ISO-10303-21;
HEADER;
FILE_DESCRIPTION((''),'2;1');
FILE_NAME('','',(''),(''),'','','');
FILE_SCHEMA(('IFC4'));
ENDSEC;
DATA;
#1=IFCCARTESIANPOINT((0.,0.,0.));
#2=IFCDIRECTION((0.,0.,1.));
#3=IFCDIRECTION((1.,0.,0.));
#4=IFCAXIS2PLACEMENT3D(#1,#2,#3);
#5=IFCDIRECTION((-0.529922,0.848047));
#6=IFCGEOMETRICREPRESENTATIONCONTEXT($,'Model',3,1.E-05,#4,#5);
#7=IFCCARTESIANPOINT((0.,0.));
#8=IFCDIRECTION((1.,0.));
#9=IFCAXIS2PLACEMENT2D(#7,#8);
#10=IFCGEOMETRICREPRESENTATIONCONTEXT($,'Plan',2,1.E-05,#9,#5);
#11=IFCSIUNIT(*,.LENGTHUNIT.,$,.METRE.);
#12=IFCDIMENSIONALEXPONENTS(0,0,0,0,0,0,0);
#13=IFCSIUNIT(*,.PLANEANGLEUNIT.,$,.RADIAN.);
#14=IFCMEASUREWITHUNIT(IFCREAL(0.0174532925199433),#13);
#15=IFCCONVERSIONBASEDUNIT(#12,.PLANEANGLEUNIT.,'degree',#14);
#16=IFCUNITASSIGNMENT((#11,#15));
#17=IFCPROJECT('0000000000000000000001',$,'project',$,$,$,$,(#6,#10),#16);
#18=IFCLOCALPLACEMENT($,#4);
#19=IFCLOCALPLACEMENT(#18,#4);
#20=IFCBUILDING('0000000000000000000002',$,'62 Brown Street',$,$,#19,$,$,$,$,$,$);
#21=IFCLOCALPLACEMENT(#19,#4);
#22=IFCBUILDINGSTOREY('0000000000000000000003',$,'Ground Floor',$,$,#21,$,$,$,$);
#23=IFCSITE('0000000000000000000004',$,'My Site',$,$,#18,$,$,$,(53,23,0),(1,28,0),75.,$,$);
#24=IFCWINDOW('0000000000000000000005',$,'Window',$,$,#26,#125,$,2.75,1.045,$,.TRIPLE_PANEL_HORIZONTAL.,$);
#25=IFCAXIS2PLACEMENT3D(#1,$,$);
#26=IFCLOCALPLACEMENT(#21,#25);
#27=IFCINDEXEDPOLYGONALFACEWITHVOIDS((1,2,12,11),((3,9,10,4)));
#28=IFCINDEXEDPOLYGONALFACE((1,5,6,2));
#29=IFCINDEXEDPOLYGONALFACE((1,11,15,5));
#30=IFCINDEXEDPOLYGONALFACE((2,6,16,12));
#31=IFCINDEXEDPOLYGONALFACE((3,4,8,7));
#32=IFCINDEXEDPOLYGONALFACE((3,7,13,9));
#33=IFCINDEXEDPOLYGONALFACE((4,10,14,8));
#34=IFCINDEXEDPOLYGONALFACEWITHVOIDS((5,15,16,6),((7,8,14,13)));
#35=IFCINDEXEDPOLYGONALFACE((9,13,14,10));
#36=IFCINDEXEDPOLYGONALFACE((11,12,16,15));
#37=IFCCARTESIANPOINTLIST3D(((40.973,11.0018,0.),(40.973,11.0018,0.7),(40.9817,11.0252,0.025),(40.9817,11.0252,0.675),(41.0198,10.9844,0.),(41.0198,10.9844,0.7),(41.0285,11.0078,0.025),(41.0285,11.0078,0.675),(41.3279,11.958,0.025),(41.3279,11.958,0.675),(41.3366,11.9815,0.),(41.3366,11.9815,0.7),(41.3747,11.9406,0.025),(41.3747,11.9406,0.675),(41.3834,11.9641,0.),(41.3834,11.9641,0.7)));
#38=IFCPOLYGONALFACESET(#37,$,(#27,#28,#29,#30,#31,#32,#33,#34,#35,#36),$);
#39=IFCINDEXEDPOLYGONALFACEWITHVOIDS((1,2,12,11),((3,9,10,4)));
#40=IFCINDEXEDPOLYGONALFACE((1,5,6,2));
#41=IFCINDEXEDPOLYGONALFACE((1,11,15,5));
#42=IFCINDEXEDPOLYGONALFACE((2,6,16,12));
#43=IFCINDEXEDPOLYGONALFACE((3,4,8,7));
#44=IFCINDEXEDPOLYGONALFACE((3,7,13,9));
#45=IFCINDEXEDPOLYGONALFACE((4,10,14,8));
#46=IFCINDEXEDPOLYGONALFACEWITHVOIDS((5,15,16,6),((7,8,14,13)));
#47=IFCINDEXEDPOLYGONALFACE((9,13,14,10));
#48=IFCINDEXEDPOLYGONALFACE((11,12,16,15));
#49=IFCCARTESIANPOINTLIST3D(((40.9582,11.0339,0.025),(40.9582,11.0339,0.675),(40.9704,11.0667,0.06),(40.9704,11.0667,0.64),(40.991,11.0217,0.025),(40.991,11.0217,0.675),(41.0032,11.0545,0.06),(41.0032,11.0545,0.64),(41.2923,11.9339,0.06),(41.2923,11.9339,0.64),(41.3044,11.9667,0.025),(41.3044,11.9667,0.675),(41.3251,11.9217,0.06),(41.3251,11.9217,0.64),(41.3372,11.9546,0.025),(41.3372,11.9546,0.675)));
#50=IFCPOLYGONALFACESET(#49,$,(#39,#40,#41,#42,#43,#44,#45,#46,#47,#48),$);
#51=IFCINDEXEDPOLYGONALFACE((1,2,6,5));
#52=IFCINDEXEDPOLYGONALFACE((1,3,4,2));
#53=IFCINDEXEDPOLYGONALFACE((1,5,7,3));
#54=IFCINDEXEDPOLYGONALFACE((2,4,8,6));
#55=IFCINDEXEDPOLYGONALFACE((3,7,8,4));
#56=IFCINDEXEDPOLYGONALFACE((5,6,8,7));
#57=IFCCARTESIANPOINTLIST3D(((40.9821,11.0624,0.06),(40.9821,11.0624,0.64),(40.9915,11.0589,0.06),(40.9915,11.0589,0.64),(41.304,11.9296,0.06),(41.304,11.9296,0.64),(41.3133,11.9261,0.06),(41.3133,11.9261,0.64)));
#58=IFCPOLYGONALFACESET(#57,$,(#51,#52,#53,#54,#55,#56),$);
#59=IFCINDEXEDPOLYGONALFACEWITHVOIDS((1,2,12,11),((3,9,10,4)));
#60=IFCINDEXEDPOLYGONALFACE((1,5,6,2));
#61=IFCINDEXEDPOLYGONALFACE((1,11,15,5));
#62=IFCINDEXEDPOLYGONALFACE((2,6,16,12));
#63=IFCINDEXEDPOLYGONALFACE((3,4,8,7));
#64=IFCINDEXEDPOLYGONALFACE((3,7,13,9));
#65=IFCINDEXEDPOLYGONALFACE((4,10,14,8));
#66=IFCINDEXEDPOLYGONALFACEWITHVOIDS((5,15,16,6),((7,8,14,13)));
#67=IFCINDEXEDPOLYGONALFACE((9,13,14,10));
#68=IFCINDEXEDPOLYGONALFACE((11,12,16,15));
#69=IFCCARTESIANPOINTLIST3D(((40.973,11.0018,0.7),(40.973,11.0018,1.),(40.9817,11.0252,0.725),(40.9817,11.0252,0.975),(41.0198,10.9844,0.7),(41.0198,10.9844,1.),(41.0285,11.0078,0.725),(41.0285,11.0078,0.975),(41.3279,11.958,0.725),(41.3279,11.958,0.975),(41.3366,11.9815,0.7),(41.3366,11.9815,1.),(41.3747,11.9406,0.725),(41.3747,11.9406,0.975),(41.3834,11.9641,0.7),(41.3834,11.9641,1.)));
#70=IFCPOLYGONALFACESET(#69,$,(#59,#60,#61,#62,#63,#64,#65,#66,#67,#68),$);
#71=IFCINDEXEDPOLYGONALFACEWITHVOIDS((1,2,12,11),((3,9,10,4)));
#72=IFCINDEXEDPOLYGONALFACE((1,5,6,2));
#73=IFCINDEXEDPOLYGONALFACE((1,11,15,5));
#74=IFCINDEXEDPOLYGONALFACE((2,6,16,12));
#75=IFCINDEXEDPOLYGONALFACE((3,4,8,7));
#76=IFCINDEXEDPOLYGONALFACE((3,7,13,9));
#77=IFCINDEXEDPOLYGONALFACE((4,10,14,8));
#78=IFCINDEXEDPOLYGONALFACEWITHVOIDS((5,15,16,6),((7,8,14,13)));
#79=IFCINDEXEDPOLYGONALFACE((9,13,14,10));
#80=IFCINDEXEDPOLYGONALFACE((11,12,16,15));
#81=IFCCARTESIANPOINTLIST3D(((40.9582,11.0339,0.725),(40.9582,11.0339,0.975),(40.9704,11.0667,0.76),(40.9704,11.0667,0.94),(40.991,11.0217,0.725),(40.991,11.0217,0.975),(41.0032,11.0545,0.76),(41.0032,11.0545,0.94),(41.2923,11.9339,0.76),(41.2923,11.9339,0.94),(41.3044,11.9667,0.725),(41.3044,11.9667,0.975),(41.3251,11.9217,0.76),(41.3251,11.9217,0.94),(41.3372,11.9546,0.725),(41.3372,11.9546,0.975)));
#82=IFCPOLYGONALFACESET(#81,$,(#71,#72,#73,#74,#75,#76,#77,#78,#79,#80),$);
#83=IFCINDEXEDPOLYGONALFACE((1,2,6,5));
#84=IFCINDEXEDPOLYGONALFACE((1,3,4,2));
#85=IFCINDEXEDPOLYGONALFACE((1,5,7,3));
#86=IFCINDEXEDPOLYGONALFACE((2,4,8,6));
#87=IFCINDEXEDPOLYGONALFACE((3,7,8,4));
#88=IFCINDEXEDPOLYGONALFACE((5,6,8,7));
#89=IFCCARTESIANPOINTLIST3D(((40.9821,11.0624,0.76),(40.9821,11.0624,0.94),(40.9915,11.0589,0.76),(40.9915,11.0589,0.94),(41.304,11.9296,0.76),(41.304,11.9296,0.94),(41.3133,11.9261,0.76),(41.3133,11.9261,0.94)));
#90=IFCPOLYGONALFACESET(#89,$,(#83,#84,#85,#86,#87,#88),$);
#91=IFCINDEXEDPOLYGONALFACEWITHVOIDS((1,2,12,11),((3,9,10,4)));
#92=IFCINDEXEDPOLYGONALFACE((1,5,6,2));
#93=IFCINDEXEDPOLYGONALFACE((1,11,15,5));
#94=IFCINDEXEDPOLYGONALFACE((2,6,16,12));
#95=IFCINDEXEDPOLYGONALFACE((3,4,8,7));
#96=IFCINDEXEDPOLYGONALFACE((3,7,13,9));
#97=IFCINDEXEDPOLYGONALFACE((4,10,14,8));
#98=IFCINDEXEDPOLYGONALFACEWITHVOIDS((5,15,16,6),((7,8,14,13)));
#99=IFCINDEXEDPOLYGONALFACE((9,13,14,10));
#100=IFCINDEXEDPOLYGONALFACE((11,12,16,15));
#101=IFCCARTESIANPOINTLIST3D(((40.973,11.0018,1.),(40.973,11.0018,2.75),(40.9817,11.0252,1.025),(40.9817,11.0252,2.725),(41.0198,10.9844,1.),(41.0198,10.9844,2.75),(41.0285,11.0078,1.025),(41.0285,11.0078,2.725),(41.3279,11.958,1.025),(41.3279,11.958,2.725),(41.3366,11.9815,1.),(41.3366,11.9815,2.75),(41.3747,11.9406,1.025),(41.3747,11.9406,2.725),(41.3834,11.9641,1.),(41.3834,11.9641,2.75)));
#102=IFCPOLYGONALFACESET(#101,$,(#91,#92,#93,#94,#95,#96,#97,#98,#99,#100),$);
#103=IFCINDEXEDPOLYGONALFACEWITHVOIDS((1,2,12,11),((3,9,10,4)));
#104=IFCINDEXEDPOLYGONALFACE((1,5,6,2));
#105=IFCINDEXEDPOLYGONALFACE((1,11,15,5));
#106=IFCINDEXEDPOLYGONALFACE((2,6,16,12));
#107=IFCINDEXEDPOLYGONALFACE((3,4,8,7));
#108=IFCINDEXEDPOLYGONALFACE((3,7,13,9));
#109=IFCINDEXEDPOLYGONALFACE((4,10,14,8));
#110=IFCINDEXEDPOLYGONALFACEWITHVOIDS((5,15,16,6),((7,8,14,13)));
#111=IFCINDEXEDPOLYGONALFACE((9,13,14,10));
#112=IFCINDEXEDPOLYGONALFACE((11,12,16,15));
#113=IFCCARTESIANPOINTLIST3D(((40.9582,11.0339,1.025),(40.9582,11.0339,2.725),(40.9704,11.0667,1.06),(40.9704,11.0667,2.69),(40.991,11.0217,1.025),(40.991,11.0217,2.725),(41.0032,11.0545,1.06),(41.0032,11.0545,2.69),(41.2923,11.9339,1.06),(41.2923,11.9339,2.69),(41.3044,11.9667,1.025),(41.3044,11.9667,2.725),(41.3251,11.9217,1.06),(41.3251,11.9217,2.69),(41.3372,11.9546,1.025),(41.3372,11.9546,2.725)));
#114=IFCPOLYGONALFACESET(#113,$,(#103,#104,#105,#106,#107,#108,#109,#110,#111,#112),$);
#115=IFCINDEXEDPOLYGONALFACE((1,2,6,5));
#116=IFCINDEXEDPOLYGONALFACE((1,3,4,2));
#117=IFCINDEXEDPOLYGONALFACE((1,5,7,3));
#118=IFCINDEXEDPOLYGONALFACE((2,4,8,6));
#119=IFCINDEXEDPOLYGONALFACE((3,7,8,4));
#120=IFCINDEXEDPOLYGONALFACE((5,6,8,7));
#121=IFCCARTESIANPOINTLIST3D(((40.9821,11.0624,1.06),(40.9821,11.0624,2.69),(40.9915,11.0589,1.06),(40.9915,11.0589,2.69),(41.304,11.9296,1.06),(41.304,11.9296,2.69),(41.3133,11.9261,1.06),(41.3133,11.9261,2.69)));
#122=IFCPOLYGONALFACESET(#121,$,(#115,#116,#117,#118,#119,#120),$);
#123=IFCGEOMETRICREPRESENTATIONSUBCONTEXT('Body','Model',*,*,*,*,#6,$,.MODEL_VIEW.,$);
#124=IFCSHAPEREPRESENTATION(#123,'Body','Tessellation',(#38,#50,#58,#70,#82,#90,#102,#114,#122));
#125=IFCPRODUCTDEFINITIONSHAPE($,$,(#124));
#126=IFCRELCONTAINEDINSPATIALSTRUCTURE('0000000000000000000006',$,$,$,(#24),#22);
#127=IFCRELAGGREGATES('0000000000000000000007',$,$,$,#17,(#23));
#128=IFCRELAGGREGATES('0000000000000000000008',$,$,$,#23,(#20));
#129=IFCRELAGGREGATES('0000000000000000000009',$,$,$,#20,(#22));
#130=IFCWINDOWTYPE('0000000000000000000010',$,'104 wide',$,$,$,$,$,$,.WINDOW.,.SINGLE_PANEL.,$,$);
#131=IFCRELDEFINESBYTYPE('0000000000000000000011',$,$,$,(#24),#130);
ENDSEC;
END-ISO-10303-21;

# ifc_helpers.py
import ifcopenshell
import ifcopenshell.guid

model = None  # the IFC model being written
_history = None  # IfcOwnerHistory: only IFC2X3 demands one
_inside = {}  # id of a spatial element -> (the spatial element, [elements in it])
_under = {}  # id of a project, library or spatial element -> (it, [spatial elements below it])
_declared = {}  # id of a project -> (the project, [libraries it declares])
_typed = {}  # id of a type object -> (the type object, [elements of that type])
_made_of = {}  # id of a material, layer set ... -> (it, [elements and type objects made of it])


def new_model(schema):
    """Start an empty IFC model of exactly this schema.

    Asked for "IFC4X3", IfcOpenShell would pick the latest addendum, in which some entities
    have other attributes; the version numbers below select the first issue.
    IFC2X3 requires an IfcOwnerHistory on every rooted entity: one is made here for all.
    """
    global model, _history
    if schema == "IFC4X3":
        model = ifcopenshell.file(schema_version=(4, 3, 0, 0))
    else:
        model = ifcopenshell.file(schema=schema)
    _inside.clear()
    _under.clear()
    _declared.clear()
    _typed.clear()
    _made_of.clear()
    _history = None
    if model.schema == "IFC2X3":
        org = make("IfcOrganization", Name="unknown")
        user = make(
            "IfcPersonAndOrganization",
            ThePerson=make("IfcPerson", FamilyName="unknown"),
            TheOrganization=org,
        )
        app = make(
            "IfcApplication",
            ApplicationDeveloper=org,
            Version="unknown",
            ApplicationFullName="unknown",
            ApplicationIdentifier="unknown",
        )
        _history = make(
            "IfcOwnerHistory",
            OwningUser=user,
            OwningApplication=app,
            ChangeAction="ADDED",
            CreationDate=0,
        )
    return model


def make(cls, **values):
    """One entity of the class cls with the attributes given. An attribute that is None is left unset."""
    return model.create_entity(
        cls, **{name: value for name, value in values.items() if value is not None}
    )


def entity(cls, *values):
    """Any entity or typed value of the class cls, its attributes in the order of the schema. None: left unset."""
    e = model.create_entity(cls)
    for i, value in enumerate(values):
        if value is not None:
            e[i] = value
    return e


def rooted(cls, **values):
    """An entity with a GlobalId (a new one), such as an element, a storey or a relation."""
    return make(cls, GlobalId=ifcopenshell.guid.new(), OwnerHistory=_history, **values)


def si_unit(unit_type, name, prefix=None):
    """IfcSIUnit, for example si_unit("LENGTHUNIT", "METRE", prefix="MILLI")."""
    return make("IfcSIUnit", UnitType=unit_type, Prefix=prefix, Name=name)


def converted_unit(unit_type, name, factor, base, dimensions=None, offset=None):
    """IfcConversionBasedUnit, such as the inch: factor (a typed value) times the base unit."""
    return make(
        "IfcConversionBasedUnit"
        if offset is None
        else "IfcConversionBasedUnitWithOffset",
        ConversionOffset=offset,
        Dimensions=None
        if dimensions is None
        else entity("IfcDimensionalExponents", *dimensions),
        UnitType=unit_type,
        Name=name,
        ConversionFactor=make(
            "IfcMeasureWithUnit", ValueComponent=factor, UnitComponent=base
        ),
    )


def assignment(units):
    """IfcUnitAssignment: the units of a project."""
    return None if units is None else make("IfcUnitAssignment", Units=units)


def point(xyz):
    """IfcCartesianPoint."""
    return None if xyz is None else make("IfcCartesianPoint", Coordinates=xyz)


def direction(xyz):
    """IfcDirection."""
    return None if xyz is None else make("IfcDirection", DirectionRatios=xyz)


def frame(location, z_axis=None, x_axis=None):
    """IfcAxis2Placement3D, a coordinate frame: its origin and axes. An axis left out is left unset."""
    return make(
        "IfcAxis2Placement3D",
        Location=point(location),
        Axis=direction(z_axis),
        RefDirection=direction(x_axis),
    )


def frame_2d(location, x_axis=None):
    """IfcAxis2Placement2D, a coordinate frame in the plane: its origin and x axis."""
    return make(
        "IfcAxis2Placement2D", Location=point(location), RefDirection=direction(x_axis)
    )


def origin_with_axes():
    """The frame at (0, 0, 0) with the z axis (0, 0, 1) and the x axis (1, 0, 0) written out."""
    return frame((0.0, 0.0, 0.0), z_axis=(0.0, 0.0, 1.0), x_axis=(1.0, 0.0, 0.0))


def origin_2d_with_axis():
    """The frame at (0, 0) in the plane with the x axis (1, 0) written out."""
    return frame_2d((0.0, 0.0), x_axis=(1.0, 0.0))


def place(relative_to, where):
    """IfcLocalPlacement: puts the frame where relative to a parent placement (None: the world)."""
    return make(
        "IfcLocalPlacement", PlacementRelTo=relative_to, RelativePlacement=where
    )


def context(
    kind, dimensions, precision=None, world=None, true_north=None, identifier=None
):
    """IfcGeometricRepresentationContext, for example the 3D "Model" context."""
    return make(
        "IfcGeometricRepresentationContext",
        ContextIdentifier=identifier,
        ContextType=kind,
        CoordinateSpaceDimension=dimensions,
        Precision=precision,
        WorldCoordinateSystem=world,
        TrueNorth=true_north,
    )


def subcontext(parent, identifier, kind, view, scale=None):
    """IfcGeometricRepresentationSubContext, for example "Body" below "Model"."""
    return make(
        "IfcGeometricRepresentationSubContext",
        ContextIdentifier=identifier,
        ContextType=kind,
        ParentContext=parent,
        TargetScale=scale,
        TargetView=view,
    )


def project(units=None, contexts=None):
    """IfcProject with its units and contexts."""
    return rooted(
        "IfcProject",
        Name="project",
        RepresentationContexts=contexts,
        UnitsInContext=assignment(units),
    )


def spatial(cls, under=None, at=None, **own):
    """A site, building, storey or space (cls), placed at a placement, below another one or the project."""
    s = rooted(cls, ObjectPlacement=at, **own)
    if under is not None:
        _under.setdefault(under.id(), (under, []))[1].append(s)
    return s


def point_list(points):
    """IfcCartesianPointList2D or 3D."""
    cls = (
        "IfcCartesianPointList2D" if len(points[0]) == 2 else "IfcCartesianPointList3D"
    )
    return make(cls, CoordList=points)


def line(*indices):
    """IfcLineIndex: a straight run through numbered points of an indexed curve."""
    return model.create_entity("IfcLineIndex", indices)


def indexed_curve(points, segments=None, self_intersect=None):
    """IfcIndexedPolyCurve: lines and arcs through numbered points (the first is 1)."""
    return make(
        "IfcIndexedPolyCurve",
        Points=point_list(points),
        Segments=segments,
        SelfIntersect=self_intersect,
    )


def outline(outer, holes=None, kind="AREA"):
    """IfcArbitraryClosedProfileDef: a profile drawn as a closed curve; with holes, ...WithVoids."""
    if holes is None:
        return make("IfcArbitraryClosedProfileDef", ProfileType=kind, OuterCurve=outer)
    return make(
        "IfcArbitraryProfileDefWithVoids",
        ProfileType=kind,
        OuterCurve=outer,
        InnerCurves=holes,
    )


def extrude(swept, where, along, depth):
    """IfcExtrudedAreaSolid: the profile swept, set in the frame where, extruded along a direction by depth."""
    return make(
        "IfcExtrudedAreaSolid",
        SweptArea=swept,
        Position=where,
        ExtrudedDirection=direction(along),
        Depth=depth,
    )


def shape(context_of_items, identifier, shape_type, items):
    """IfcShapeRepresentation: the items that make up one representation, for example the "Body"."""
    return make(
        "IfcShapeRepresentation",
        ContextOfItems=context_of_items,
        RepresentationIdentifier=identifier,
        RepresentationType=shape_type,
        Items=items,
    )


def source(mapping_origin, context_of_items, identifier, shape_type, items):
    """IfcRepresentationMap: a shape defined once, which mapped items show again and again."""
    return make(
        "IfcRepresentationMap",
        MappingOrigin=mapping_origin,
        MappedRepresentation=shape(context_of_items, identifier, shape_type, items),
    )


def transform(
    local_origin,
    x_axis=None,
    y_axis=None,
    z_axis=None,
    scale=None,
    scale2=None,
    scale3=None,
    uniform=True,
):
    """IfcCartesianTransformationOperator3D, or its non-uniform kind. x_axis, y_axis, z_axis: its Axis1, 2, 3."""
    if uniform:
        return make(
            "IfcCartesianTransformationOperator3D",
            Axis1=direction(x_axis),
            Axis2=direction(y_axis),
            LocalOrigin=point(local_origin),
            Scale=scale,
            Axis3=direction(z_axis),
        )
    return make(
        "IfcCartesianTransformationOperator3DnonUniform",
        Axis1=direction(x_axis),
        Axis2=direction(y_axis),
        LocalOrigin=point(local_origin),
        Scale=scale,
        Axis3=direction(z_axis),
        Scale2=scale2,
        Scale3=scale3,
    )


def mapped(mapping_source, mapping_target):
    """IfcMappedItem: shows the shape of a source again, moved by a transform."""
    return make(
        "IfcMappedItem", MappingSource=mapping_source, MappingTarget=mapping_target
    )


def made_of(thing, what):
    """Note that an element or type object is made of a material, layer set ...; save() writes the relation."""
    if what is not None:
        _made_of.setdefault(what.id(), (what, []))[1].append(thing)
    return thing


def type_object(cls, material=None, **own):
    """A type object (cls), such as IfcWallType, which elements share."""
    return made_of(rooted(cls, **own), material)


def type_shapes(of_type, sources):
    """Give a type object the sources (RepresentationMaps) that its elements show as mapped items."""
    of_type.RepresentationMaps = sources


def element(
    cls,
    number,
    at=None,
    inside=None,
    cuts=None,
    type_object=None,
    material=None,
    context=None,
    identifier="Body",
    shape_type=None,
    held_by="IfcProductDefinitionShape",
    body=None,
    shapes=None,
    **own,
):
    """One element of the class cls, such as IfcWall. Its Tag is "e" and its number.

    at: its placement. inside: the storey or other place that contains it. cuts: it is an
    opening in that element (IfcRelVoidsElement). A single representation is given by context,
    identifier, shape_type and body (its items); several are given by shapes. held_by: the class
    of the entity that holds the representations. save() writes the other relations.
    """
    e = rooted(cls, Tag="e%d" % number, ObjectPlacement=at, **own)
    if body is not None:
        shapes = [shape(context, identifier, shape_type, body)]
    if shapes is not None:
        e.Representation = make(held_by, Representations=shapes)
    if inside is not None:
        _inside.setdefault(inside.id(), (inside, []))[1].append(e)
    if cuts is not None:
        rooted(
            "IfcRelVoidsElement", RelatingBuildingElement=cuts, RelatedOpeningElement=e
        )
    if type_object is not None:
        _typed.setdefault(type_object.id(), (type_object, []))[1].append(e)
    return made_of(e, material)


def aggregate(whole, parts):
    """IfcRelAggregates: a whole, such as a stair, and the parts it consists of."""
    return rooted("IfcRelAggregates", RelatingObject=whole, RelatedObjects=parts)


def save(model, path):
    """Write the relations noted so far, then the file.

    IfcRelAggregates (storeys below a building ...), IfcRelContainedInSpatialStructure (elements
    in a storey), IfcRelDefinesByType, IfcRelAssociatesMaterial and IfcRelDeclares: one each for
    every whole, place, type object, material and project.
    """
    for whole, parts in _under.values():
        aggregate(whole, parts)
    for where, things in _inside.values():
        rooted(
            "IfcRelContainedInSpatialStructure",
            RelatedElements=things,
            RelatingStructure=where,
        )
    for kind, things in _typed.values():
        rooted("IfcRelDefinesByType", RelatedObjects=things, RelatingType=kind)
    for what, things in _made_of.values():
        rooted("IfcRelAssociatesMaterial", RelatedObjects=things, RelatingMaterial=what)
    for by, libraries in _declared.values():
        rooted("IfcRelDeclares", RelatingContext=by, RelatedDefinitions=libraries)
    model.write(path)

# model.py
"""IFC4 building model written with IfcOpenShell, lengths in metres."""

from ifc_helpers import new_model, entity, si_unit, converted_unit, direction, frame, origin_with_axes, origin_2d_with_axis, place, context, subcontext, project, spatial, line, indexed_curve, outline, extrude, shape, source, transform, mapped, type_object, type_shapes, element, save


model = new_model("IFC4")

# Units and contexts
model_context = context("Model", 3, precision=1e-05, world=origin_with_axes(), true_north=direction((-0.529922, 0.848047)))
plan_context = context("Plan", 2, precision=1e-05, world=origin_2d_with_axis(), true_north=direction((-0.529922, 0.848047)))
body_context_1 = subcontext(model_context, "Body", "Model", "MODEL_VIEW")
body_context_2 = subcontext(plan_context, "Body", "Plan", "PLAN_VIEW")
ifc_project = project(units=[si_unit("LENGTHUNIT", "METRE"), converted_unit("PLANEANGLEUNIT", "degree", entity("IfcReal", 0.0174532925199433), si_unit("PLANEANGLEUNIT", "RADIAN"), dimensions=[0, 0, 0, 0, 0, 0, 0])], contexts=[model_context, plan_context])

# Site, building, storey
site_placement = place(None, origin_with_axes())
site = spatial("IfcSite", under=ifc_project, at=site_placement, Name="My Site", RefLatitude=(53, 23, 0), RefLongitude=(1, 28, 0), RefElevation=75.0)
building_placement = place(site_placement, origin_with_axes())
building = spatial("IfcBuilding", under=site, at=building_placement, Name="62 Brown Street")
storey_placement = place(building_placement, origin_with_axes())
storey = spatial("IfcBuildingStorey", under=building, at=storey_placement, Name="Ground Floor")

# Window
window_type_1 = type_object("IfcWindowType", Name="104 wide", PartitioningType="SINGLE_PANEL", PredefinedType="WINDOW")
shared_shape_1 = source(origin_with_axes(), body_context_1, "Body", "SweptSolid", [
    extrude(outline(indexed_curve([(0.0, 0.0), (1.045, 0.0), (1.045, 0.7), (0.0, 0.7)], segments=[line(1, 2, 3, 4, 1)]), holes=[indexed_curve([(0.025, 0.025), (1.02, 0.025), (1.02, 0.675), (0.025, 0.675)], segments=[line(1, 2, 3, 4, 1)])]), frame((0.0, 0.15, 0.0), z_axis=(0.0, -1.0, 0.0), x_axis=(1.0, 0.0, 0.0)), (0.0, 0.0, -1.0), 0.05),
    extrude(outline(indexed_curve([(0.0, 0.0), (0.995, 0.0), (0.995, 0.65), (0.0, 0.65)], segments=[line(1, 2, 3, 4, 1)]), holes=[indexed_curve([(0.035, 0.035), (0.96, 0.035), (0.96, 0.615), (0.035, 0.615)], segments=[line(1, 2, 3, 4, 1)])]), frame((0.025, 0.19, 0.025), z_axis=(0.0, -1.0, 0.0), x_axis=(1.0, 0.0, 0.0)), (0.0, 0.0, -1.0), 0.035),
    extrude(outline(indexed_curve([(0.035, 0.035), (0.96, 0.035), (0.96, 0.615), (0.035, 0.615)], segments=[line(1, 2, 3, 4, 1)])), frame((0.025, 0.2025, 0.025), z_axis=(0.0, -1.0, 0.0), x_axis=(1.0, 0.0, 0.0)), (0.0, 0.0, -1.0), 0.01),
    extrude(outline(indexed_curve([(0.0, 0.0), (1.045, 0.0), (1.045, 0.3), (0.0, 0.3)], segments=[line(1, 2, 3, 4, 1)]), holes=[indexed_curve([(0.025, 0.025), (1.02, 0.025), (1.02, 0.275), (0.025, 0.275)], segments=[line(1, 2, 3, 4, 1)])]), frame((0.0, 0.15, 0.7), z_axis=(0.0, -1.0, 0.0), x_axis=(1.0, 0.0, 0.0)), (0.0, 0.0, -1.0), 0.05),
    extrude(outline(indexed_curve([(0.0, 0.0), (0.995, 0.0), (0.995, 0.25), (0.0, 0.25)], segments=[line(1, 2, 3, 4, 1)]), holes=[indexed_curve([(0.035, 0.035), (0.96, 0.035), (0.96, 0.215), (0.035, 0.215)], segments=[line(1, 2, 3, 4, 1)])]), frame((0.025, 0.19, 0.725), z_axis=(0.0, -1.0, 0.0), x_axis=(1.0, 0.0, 0.0)), (0.0, 0.0, -1.0), 0.035),
    extrude(outline(indexed_curve([(0.035, 0.035), (0.96, 0.035), (0.96, 0.215), (0.035, 0.215)], segments=[line(1, 2, 3, 4, 1)])), frame((0.025, 0.2025, 0.725), z_axis=(0.0, -1.0, 0.0), x_axis=(1.0, 0.0, 0.0)), (0.0, 0.0, -1.0), 0.01),
    extrude(outline(indexed_curve([(0.0, 0.0), (1.045, 0.0), (1.045, 1.75), (0.0, 1.75)], segments=[line(1, 2, 3, 4, 1)]), holes=[indexed_curve([(0.025, 0.025), (1.02, 0.025), (1.02, 1.725), (0.025, 1.725)], segments=[line(1, 2, 3, 4, 1)])]), frame((0.0, 0.15, 1.0), z_axis=(0.0, -1.0, 0.0), x_axis=(1.0, 0.0, 0.0)), (0.0, 0.0, -1.0), 0.05),
    extrude(outline(indexed_curve([(0.0, 0.0), (0.995, 0.0), (0.995, 1.7), (0.0, 1.7)], segments=[line(1, 2, 3, 4, 1)]), holes=[indexed_curve([(0.035, 0.035), (0.96, 0.035), (0.96, 1.665), (0.035, 1.665)], segments=[line(1, 2, 3, 4, 1)])]), frame((0.025, 0.19, 1.025), z_axis=(0.0, -1.0, 0.0), x_axis=(1.0, 0.0, 0.0)), (0.0, 0.0, -1.0), 0.035),
    extrude(outline(indexed_curve([(0.035, 0.035), (0.96, 0.035), (0.96, 1.665), (0.035, 1.665)], segments=[line(1, 2, 3, 4, 1)])), frame((0.025, 0.2025, 1.025), z_axis=(0.0, -1.0, 0.0), x_axis=(1.0, 0.0, 0.0)), (0.0, 0.0, -1.0), 0.01),
])
shared_shape_2 = source(origin_with_axes(), body_context_2, "Body", "Curve2D", [
    entity("IfcIndexedPolyCurve", entity("IfcCartesianPointList2D", [[0.025, 0.15], [1.02, 0.15]])),
    entity("IfcIndexedPolyCurve", entity("IfcCartesianPointList2D", [[0.0, 0.2], [0.025, 0.2], [0.025, 0.15], [0.0, 0.15]]), [entity("IfcLineIndex", [1, 2, 3, 4, 1])]),
    entity("IfcIndexedPolyCurve", entity("IfcCartesianPointList2D", [[1.045, 0.2], [1.02, 0.2], [1.02, 0.15], [1.045, 0.15]]), [entity("IfcLineIndex", [1, 2, 3, 4, 1])]),
    entity("IfcIndexedPolyCurve", entity("IfcCartesianPointList2D", [[0.025, 0.19], [0.06, 0.19], [0.06, 0.225], [0.025, 0.225]]), [entity("IfcLineIndex", [1, 2, 3, 4, 1])]),
    entity("IfcIndexedPolyCurve", entity("IfcCartesianPointList2D", [[1.02, 0.19], [0.985, 0.19], [0.985, 0.225], [1.02, 0.225]]), [entity("IfcLineIndex", [1, 2, 3, 4, 1])]),
    entity("IfcIndexedPolyCurve", entity("IfcCartesianPointList2D", [[0.06, 0.19], [0.985, 0.19]])),
    entity("IfcIndexedPolyCurve", entity("IfcCartesianPointList2D", [[0.06, 0.225], [0.985, 0.225]])),
    entity("IfcIndexedPolyCurve", entity("IfcCartesianPointList2D", [[0.06, 0.2075], [0.985, 0.2075]])),
])
type_shapes(window_type_1, [shared_shape_1, shared_shape_2])
placement_1 = place(storey_placement, frame((39.024, 5.1755, 0.0), z_axis=(0.0, 0.0, 1.0), x_axis=(0.347944, 0.937515, 0.0)))
placement_2 = place(placement_1, frame((6.1404, 0.0, 0.0), z_axis=(0.0, 0.0, 1.0), x_axis=(1.0, 0.0, 0.0)))
window_1_placement = place(placement_2, frame((0.0, 0.0, 0.0), z_axis=(0.0, 0.0, 1.0), x_axis=(1.0, 0.0, 0.0)))
element("IfcWindow", 1, at=window_1_placement, inside=storey, type_object=window_type_1, Name="Window", OverallHeight=2.75, OverallWidth=1.045, PartitioningType="TRIPLE_PANEL_HORIZONTAL", shapes=[
    shape(body_context_1, "Body", "MappedRepresentation", [mapped(shared_shape_1, transform((0.0, 0.0, 0.0), x_axis=(1.0, 0.0, 0.0), y_axis=(0.0, 1.0, 0.0), z_axis=(0.0, 0.0, 1.0), scale=1.0))]),
    shape(body_context_2, "Body", "MappedRepresentation", [mapped(shared_shape_2, transform((0.0, 0.0, 0.0), x_axis=(1.0, 0.0, 0.0), y_axis=(0.0, 1.0, 0.0), z_axis=(0.0, 0.0, 1.0), scale=1.0))]),
])

save(model, "model.ifc")
